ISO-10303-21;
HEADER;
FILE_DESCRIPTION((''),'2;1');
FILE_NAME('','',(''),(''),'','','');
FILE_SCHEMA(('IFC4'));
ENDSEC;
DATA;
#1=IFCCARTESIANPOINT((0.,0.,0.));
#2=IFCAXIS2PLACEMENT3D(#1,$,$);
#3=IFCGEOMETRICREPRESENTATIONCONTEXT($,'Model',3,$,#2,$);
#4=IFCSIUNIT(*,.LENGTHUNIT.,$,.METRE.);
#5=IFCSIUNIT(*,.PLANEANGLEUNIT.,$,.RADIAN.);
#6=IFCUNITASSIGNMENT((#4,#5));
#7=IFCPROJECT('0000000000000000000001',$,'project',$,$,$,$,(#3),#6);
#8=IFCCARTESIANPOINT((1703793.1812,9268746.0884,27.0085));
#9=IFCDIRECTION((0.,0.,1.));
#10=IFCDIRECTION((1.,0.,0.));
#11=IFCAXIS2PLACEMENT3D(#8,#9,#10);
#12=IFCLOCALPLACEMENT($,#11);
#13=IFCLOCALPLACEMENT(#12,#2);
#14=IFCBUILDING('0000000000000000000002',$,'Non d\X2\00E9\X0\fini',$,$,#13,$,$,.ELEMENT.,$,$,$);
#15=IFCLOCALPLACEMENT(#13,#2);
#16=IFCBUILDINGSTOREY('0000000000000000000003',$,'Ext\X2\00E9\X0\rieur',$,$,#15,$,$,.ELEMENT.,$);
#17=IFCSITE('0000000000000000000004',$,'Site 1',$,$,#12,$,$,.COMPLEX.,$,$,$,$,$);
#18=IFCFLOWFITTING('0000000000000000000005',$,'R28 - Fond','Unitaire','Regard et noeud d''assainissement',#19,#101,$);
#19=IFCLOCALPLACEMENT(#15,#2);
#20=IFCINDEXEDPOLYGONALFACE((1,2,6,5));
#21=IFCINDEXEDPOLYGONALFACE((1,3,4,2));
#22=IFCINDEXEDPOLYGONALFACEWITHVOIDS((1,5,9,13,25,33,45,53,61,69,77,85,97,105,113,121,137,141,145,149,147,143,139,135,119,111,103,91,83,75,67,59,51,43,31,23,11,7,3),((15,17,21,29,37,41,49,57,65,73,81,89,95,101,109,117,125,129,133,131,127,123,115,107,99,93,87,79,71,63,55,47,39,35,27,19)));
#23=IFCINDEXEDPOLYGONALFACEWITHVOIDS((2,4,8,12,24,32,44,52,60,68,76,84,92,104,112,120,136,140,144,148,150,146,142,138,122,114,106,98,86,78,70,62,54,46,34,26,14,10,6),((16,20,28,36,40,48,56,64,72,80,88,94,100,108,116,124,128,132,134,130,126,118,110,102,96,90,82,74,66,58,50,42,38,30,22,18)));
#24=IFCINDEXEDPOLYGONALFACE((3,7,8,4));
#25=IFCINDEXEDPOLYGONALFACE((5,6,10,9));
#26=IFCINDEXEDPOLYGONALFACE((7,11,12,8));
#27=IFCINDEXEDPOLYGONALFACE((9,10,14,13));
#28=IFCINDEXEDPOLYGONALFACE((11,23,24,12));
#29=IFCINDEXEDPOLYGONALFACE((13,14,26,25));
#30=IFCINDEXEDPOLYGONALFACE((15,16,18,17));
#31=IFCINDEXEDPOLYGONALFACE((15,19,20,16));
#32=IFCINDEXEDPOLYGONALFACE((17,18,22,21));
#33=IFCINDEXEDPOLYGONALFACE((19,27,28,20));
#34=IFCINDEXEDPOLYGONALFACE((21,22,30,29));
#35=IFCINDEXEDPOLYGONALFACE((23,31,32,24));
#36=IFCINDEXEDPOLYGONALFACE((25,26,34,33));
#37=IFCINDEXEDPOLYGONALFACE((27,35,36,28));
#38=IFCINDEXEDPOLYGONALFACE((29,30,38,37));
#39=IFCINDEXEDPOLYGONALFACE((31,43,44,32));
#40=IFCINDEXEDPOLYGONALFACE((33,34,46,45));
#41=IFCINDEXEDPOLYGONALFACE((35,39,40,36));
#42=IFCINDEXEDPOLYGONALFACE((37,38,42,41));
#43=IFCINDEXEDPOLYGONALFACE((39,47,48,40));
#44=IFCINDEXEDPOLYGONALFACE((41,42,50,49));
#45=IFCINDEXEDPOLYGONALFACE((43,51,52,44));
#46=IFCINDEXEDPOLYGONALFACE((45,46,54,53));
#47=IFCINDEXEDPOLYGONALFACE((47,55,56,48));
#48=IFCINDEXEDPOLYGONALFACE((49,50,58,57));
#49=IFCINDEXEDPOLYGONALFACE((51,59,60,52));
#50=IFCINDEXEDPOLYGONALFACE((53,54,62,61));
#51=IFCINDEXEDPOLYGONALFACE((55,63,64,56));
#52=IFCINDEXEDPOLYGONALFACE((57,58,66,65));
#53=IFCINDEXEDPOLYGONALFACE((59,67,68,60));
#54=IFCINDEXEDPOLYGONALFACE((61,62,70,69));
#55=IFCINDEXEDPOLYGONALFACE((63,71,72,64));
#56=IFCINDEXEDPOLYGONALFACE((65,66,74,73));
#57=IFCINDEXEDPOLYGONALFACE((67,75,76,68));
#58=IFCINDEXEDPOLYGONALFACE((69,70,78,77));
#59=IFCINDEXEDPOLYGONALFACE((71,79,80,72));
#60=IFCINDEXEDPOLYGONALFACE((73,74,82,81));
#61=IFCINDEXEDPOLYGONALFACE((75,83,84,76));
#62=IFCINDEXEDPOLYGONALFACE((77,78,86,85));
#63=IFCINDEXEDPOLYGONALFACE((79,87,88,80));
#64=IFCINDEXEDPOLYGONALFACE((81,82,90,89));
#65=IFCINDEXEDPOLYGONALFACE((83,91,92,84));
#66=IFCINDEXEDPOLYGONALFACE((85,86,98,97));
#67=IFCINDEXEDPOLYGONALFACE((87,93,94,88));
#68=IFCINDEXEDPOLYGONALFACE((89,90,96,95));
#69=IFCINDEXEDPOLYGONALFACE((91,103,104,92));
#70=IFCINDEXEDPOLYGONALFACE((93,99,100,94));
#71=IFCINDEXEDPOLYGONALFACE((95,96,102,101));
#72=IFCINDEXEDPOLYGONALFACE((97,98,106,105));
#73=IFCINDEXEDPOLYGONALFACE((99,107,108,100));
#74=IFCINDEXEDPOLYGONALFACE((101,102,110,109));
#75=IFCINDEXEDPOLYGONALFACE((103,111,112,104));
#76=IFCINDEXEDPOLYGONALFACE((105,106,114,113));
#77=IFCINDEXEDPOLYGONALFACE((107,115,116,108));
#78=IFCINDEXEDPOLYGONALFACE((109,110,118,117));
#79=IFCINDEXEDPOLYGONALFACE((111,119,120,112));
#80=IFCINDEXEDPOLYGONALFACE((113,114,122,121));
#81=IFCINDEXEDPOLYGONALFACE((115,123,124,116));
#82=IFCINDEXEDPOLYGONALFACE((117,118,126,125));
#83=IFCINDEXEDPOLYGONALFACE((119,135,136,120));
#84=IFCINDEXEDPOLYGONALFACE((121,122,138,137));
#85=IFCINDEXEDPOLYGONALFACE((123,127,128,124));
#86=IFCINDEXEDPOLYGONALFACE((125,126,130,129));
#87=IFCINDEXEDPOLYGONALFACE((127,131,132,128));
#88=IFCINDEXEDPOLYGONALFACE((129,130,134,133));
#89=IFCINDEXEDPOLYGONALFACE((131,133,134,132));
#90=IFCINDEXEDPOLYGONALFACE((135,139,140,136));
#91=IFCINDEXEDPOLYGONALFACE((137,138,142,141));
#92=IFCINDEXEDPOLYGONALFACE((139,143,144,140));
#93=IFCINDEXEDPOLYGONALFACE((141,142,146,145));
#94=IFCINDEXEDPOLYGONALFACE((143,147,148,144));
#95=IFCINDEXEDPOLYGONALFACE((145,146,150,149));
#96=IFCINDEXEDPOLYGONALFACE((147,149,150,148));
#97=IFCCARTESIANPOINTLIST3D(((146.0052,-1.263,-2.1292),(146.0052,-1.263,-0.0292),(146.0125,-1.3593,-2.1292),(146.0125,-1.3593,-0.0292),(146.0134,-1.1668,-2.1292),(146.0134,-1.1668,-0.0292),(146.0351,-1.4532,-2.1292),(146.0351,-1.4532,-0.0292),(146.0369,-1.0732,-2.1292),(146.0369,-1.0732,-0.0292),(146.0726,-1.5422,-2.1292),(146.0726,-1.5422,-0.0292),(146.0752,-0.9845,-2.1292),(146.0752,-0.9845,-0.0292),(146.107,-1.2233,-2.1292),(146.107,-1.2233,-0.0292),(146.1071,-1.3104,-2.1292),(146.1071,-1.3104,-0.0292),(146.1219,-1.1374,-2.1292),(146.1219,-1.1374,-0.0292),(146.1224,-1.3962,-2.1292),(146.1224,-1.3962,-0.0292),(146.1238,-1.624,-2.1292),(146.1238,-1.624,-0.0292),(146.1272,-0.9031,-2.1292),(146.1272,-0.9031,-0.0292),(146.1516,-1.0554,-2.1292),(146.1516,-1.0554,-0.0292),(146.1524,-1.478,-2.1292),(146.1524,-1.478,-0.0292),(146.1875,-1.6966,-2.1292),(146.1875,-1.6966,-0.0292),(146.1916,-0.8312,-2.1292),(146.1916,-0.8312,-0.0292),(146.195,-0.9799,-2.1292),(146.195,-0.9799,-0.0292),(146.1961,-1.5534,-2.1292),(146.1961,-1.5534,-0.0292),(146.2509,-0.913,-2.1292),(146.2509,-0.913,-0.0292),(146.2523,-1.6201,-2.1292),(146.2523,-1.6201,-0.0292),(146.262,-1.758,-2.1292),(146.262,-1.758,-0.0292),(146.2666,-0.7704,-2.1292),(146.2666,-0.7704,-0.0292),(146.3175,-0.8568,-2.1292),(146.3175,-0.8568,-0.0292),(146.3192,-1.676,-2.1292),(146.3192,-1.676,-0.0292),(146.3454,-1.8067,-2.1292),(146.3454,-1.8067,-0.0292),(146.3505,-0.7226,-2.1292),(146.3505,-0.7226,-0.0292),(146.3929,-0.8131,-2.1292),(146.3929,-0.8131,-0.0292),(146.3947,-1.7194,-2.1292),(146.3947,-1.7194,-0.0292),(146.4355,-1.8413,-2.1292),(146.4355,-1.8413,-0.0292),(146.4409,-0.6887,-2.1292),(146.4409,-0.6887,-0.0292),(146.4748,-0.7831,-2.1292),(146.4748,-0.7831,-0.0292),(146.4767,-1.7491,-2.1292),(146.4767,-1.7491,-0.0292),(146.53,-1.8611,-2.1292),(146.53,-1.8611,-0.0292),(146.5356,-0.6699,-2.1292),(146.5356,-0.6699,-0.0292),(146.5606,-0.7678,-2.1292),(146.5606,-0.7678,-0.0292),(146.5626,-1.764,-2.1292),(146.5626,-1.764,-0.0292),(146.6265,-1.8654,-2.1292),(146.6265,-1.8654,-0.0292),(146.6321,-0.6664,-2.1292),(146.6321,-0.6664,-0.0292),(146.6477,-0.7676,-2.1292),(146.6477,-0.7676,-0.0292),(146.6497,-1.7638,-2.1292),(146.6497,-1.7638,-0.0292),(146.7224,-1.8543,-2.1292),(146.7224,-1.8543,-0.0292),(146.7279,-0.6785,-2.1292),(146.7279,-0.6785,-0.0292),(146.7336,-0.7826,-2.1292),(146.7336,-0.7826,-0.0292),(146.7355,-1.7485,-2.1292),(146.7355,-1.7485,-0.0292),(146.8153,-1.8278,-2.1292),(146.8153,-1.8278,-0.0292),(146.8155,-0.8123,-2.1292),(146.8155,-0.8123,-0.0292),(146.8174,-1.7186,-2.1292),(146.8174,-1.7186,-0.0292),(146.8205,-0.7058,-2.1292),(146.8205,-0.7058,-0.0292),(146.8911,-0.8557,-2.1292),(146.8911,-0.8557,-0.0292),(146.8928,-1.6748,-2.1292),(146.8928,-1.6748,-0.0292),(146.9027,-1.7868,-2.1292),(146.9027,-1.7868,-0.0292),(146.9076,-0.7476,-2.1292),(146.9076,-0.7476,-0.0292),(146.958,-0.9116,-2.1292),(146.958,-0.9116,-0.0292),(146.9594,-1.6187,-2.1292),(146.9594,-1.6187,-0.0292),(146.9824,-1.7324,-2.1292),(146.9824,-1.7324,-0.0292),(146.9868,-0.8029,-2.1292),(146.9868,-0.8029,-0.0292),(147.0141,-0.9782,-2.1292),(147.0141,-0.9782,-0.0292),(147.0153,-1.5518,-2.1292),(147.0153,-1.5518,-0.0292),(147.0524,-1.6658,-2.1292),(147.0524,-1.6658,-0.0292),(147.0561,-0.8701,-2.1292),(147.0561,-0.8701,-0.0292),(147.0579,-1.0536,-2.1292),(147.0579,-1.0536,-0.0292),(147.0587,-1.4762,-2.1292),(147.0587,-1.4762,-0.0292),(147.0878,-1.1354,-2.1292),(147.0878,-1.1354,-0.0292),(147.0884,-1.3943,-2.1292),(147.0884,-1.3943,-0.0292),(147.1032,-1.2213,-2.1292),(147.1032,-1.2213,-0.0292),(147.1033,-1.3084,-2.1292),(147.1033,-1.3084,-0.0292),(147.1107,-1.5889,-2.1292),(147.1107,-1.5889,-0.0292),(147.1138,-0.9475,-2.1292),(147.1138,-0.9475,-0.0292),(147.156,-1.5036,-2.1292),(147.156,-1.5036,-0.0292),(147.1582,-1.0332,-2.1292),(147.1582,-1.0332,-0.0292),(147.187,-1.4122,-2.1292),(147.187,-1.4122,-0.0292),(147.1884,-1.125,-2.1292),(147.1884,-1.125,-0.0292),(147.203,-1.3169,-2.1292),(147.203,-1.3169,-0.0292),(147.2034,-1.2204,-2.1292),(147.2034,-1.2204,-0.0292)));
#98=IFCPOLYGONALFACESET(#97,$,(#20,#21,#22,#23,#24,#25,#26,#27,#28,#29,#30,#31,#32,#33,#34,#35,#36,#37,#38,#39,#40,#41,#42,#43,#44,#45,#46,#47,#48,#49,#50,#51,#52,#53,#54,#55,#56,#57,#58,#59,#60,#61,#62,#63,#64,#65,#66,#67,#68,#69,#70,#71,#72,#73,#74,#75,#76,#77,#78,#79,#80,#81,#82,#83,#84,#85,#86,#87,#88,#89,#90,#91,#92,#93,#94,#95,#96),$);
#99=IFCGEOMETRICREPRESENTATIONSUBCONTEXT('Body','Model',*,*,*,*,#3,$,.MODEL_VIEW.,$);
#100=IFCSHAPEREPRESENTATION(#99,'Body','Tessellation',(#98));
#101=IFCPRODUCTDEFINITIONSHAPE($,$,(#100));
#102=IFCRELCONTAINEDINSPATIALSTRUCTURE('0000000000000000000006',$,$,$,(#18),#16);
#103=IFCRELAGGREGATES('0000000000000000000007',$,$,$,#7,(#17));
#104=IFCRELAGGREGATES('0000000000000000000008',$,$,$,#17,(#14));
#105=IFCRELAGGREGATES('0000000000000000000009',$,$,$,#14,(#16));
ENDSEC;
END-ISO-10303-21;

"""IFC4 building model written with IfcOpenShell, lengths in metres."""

from ifc_helpers import new_model, si_unit, frame, origin, origin_2d, place, context, subcontext, project, spatial, hollow_circle, extrude, element, save


model = new_model("IFC4")

# Units and contexts
model_context = context("Model", 3, world=origin())
body_context = subcontext(model_context, "Body", "Model", "MODEL_VIEW")
ifc_project = project(units=[si_unit("LENGTHUNIT", "METRE"), si_unit("PLANEANGLEUNIT", "RADIAN")], contexts=[model_context])

# Site, building, storey
site_placement = place(None, frame((1703793.1812, 9268746.0884, 27.0085), z_axis=(0.0, 0.0, 1.0), x_axis=(1.0, 0.0, 0.0)))
site = spatial("IfcSite", under=ifc_project, at=site_placement, Name="Site 1", CompositionType="COMPLEX")
building_placement = place(site_placement, origin())
building = spatial("IfcBuilding", under=site, at=building_placement, Name="Non défini", CompositionType="ELEMENT")
storey_placement = place(building_placement, origin())
storey = spatial("IfcBuildingStorey", under=building, at=storey_placement, Name="Extérieur", CompositionType="ELEMENT")

# Flow fitting
flow_fitting_1_placement = place(storey_placement, origin())
element("IfcFlowFitting", 1, at=flow_fitting_1_placement, inside=storey, Name="R28 - Fond", Description="Unitaire", ObjectType="Regard et noeud d'assainissement", context=body_context, shape_type="SweptSolid", body=[
    extrude(hollow_circle(Radius=0.6, WallThickness=0.1, at=origin_2d()), frame((146.6051, -1.2658, -2.1292), z_axis=(0.0, 0.0, 1.0), x_axis=(0.996368, -0.085154, 0.0)), (0.0, 0.0, 1.0), 2.1),
])

save(model, "model.ifc")
